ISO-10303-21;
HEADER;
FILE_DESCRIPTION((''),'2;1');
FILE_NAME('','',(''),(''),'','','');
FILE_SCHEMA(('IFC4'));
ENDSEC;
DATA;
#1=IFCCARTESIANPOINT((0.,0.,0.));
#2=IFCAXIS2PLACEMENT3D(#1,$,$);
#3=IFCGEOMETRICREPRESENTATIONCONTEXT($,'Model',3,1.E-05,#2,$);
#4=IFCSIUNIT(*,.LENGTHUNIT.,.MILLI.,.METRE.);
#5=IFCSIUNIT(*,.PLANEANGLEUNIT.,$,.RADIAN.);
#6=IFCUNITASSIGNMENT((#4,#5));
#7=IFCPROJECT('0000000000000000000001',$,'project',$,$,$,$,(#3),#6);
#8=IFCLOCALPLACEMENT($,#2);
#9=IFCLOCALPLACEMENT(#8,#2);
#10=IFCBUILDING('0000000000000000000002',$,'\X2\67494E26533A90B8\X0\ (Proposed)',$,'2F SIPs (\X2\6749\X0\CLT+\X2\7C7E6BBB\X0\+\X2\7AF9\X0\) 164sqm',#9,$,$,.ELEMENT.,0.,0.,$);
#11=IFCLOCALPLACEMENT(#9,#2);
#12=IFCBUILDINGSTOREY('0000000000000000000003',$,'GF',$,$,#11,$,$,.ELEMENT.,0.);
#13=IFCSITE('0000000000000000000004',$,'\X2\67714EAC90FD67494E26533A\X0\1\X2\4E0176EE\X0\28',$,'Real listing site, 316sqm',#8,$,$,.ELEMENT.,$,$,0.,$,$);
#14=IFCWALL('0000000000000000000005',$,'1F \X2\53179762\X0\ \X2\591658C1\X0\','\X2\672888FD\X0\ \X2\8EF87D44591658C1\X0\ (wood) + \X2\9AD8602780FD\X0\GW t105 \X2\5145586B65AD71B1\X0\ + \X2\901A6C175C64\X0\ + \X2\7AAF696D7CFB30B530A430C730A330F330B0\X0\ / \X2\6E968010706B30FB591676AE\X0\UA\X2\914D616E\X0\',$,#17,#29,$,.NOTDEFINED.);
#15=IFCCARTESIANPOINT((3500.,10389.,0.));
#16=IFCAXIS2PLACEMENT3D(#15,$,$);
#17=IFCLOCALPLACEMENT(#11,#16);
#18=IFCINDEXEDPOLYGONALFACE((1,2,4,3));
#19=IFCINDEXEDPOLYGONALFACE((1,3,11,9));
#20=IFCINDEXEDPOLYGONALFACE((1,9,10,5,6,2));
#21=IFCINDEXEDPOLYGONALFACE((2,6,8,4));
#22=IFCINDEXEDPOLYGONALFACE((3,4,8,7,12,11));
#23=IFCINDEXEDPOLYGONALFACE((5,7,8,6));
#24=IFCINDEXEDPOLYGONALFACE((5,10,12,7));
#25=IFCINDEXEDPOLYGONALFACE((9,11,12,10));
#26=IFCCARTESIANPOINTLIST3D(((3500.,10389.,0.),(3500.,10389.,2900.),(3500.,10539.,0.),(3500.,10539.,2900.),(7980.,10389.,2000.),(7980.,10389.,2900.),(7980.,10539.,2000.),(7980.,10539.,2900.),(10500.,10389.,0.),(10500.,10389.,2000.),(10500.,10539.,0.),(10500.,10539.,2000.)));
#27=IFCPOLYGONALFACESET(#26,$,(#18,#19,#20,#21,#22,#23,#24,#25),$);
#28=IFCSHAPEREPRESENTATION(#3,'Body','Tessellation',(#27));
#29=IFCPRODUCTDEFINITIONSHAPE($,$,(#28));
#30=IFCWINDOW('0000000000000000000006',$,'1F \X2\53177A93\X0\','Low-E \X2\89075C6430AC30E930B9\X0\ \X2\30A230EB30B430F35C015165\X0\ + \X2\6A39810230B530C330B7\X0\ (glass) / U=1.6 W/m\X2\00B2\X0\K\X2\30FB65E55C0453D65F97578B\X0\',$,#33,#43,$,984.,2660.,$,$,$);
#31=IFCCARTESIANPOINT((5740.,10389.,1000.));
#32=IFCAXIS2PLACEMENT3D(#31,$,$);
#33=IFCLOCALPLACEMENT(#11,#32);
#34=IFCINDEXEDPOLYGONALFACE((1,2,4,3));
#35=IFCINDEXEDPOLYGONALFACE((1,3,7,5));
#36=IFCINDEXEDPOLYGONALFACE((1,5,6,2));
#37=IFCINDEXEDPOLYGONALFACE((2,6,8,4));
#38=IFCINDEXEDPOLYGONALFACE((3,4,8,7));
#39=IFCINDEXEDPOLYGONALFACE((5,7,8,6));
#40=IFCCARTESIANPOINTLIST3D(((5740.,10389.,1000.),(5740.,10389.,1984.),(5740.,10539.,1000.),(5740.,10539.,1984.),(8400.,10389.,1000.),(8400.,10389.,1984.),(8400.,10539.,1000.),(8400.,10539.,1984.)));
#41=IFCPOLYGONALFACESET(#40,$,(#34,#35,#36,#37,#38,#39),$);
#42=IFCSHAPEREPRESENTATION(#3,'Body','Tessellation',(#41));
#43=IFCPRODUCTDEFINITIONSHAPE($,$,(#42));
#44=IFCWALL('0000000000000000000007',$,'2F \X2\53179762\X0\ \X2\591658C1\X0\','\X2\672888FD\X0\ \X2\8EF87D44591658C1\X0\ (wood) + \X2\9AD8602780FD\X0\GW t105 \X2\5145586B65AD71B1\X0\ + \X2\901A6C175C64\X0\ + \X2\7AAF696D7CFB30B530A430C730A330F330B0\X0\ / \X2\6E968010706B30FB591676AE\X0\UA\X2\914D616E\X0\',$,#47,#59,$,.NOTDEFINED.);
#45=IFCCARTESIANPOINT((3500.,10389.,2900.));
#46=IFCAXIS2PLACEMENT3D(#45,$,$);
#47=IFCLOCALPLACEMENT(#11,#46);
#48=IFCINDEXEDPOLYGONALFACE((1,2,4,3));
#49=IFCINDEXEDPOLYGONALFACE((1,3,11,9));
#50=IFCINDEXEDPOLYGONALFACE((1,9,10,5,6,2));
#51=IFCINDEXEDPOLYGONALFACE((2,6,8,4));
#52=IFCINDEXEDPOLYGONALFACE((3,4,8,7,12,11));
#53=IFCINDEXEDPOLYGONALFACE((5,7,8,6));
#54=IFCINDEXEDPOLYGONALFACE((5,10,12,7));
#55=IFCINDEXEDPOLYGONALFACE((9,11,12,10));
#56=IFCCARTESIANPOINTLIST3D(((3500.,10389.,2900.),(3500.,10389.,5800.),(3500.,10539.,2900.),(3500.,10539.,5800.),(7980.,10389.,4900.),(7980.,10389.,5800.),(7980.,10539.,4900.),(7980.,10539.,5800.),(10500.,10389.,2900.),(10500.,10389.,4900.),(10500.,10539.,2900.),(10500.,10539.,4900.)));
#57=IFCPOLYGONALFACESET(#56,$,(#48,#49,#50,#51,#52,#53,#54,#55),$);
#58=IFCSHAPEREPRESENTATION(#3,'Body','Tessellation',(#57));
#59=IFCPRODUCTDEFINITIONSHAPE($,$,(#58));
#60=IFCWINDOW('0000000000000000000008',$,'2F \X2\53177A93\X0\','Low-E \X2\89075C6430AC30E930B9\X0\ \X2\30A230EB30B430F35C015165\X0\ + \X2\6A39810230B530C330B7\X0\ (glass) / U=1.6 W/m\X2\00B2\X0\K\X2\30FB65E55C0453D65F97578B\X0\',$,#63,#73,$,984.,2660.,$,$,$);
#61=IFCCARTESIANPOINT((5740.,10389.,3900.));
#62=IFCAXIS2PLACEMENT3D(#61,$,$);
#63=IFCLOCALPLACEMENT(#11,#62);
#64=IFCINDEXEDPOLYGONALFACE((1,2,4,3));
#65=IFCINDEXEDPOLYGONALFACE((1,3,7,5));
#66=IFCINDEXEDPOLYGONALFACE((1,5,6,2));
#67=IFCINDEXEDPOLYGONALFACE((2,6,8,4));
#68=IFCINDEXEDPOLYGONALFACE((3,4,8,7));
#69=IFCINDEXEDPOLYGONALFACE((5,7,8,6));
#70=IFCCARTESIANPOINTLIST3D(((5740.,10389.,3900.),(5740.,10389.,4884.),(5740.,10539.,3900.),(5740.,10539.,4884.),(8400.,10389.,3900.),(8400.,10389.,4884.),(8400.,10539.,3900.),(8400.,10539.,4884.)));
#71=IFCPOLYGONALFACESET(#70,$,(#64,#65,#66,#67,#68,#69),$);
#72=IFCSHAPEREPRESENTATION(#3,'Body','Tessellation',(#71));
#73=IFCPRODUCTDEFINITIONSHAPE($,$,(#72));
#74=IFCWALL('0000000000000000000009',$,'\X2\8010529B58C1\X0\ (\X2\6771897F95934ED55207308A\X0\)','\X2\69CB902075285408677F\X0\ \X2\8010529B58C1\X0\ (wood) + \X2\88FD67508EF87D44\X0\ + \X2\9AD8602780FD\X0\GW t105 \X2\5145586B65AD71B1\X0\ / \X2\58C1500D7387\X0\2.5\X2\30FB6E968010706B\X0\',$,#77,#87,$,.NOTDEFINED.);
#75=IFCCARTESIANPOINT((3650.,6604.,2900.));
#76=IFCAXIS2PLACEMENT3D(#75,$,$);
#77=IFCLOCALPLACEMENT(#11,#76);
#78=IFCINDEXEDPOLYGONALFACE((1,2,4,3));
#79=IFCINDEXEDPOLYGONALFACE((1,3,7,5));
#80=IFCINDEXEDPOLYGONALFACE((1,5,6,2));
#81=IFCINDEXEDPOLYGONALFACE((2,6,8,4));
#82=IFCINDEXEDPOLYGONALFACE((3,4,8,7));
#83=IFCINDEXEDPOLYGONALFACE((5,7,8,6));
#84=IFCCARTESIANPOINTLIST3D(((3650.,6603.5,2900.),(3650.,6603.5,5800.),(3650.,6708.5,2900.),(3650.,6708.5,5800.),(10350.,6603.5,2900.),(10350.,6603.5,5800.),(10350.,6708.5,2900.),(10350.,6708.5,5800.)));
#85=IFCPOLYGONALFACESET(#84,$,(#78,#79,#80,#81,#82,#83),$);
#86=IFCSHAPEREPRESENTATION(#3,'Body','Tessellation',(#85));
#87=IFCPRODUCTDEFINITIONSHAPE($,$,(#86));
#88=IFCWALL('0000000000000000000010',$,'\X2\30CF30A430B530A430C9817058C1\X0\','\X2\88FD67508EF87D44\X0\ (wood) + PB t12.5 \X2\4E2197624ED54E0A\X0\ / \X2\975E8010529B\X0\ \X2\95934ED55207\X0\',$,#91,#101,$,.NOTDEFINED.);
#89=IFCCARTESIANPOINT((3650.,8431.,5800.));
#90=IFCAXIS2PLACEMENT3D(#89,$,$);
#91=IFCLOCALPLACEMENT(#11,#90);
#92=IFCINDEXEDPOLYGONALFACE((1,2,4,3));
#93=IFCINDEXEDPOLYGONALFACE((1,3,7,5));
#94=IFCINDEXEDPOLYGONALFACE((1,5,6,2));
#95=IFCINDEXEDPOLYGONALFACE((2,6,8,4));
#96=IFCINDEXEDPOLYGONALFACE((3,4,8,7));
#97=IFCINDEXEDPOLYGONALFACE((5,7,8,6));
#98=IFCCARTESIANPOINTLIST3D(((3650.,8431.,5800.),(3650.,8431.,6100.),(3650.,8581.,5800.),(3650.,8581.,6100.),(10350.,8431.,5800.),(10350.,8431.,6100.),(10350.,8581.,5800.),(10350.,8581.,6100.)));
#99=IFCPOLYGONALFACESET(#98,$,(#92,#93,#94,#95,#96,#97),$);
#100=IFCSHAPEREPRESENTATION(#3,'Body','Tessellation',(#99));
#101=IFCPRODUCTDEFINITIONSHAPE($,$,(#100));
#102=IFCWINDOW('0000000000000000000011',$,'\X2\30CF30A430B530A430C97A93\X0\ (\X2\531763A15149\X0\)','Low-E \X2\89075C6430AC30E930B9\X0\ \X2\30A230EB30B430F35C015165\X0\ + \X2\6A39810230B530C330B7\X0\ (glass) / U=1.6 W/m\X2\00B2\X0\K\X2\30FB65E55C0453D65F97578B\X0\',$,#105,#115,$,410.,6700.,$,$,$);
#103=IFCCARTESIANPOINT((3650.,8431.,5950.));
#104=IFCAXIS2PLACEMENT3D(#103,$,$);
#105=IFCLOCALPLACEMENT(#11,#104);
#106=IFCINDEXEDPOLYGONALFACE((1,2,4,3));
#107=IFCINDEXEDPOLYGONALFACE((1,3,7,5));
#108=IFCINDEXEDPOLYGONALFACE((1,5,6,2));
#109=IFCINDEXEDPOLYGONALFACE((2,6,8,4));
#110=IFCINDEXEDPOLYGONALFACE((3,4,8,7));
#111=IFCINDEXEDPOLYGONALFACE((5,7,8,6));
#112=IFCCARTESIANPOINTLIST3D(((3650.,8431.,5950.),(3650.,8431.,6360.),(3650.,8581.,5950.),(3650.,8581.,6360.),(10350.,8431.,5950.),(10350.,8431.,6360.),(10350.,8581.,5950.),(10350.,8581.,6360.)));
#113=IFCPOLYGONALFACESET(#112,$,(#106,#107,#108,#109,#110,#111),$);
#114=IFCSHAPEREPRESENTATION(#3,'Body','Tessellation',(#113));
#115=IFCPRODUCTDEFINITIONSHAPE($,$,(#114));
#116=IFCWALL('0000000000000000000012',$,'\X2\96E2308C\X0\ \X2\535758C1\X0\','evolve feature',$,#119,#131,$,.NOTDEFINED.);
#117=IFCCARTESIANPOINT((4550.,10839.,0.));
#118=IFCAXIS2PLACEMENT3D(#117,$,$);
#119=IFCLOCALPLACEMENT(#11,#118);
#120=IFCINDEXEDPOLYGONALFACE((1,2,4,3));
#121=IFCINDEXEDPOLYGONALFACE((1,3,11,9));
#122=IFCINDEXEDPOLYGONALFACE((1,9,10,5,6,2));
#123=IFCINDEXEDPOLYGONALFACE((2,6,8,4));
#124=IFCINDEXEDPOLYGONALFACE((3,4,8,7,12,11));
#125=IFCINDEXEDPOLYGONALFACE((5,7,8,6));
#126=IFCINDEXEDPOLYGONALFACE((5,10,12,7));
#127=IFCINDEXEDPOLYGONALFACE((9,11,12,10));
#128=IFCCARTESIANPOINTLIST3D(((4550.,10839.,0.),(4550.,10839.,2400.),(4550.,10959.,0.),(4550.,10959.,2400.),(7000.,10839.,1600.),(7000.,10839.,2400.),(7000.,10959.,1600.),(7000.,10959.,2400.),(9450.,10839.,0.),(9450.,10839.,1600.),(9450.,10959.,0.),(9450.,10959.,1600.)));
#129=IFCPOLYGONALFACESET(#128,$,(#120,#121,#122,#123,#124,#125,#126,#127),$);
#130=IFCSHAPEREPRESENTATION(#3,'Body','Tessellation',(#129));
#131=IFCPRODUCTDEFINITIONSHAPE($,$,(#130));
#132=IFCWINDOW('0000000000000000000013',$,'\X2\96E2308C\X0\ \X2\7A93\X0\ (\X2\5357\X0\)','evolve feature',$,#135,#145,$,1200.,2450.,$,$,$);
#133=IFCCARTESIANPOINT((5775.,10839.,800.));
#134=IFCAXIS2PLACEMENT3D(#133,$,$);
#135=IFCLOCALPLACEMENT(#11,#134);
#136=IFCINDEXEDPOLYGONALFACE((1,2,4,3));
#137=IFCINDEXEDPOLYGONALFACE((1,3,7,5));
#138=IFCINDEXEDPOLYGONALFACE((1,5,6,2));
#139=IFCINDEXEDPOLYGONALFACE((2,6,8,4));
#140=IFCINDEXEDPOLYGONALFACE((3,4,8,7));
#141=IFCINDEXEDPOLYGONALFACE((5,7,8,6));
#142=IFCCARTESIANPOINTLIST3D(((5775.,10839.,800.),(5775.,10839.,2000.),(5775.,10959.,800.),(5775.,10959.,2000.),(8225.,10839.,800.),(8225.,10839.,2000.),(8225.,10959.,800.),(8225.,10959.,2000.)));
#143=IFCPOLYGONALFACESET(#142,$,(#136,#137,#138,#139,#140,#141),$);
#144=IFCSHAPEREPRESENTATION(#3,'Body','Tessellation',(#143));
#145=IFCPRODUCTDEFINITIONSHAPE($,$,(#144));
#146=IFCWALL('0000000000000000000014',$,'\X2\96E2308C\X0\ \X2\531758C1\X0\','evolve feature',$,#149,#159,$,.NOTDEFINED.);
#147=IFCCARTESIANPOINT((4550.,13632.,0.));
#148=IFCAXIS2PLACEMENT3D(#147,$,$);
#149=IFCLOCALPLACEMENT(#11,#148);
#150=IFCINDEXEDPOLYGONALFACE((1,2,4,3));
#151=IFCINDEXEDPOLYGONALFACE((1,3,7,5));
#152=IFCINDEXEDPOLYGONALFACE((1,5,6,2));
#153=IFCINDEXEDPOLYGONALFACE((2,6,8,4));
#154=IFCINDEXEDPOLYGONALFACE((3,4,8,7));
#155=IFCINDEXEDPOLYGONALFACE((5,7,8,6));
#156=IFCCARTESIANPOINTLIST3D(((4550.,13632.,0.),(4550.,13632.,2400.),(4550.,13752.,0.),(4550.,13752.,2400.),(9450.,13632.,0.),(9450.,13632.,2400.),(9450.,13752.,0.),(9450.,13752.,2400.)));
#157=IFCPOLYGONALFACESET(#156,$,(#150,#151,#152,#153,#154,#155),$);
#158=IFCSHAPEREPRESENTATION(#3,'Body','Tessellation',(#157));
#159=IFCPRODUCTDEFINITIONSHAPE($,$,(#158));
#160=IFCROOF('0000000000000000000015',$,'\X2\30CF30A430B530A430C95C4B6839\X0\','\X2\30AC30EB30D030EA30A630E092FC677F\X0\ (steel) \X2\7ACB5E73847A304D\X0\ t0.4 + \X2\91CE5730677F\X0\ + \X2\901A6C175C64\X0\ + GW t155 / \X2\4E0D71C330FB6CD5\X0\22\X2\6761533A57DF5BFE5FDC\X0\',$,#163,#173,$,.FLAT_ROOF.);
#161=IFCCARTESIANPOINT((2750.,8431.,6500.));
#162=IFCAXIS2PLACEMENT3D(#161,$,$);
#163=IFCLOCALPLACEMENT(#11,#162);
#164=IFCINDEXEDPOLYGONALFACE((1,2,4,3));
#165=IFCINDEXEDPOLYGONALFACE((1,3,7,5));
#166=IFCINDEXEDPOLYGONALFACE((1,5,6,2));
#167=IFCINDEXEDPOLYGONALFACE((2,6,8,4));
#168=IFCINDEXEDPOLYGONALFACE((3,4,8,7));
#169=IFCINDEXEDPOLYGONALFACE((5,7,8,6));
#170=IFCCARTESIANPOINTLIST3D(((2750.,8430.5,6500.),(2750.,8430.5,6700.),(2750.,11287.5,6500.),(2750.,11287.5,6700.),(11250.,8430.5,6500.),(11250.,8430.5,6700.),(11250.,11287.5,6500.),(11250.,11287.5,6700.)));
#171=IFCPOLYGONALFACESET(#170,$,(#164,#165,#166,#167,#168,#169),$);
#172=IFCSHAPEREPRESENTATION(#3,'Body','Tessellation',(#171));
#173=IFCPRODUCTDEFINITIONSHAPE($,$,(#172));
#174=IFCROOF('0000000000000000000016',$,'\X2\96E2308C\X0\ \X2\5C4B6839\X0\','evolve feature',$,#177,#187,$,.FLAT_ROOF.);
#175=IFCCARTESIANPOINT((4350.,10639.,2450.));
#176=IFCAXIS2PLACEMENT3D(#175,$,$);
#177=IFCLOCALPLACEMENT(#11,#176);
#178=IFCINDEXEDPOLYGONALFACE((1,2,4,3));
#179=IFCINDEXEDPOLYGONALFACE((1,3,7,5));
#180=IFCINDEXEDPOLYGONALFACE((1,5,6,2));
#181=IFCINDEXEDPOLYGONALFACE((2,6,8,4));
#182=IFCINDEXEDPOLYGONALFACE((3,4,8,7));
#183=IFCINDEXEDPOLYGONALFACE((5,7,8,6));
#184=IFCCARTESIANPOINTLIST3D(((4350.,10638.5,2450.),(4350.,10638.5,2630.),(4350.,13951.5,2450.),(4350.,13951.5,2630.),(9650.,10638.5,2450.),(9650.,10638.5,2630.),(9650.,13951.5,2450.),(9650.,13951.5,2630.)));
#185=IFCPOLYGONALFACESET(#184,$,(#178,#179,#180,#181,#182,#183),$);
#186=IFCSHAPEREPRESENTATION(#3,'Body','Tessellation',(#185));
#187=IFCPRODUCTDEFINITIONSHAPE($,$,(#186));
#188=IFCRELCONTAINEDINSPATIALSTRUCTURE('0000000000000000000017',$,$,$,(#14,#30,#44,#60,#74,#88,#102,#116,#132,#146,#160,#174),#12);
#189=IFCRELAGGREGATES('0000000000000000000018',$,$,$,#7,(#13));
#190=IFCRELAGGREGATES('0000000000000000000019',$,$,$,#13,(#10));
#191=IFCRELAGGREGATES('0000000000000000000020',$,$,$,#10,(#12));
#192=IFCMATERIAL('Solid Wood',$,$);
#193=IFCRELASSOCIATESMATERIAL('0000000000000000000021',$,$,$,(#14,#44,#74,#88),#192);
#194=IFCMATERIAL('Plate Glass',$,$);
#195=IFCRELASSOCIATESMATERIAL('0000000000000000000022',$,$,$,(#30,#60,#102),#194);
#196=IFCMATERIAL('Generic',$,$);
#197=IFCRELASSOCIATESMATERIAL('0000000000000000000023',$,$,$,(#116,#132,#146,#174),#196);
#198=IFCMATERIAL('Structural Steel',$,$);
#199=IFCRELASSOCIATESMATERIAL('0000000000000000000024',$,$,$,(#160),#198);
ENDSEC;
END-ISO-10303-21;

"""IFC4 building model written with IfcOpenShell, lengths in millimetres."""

from ifc_helpers import new_model, si_unit, frame, frame_2d, origin, place, context, project, spatial, rectangle, extrude, material, element, fill, save


model = new_model("IFC4")

# Units and contexts
model_context = context("Model", 3, precision=1e-05, world=origin())
ifc_project = project(units=[si_unit("LENGTHUNIT", "METRE", prefix="MILLI"), si_unit("PLANEANGLEUNIT", "RADIAN")], contexts=[model_context])

# Site, building, storey
site_placement = place(None, origin())
site = spatial("IfcSite", under=ifc_project, at=site_placement, Name="東京都杉並区1丁目28", ObjectType="Real listing site, 316sqm", CompositionType="ELEMENT", RefElevation=0.0)
building_placement = place(site_placement, origin())
building = spatial("IfcBuilding", under=site, at=building_placement, Name="杉並区邸 (Proposed)", ObjectType="2F SIPs (杉CLT+籾殻+竹) 164sqm", CompositionType="ELEMENT", ElevationOfRefHeight=0.0, ElevationOfTerrain=0.0)
storey_placement = place(building_placement, origin())
storey = spatial("IfcBuildingStorey", under=building, at=storey_placement, Name="GF", CompositionType="ELEMENT", Elevation=0.0)

# Shared definitions
ifc_material_1 = material(Name="Generic")

# Wall, opening, window
ifc_material_2 = material(Name="Solid Wood")
wall_1_placement = place(storey_placement, frame((3500.0, 10389.0, 0.0)))
wall_1 = element("IfcWall", 1, at=wall_1_placement, inside=storey, material=ifc_material_2, Name="1F 北面 外壁", Description="木製 軸組外壁 (wood) + 高性能GW t105 充填断熱 + 通気層 + 窯業系サイディング / 準耐火・外皮UA配慮", PredefinedType="NOTDEFINED", context=model_context, shape_type="SweptSolid", body=[
    extrude(rectangle(XDim=7000.0, YDim=150.0, at=frame_2d((3500.0, 75.0))), frame((3500.0, 10389.0, 0.0)), (0.0, 0.0, 1.0), 2900.0),
])
opening_1_placement = place(storey_placement, frame((5740.0, 10389.0, 1000.0)))
opening_1 = element("IfcOpeningElement", 2, at=opening_1_placement, cuts=wall_1, PredefinedType="NOTDEFINED", context=model_context, shape_type="SweptSolid", body=[
    extrude(rectangle(XDim=2660.0, YDim=150.0, at=frame_2d((1330.0, 75.0))), frame((5740.0, 10389.0, 1000.0)), (0.0, 0.0, 1.0), 984.0),
])
ifc_material_3 = material(Name="Plate Glass")
window_1_placement = place(storey_placement, frame((5740.0, 10389.0, 1000.0)))
window_1 = element("IfcWindow", 3, at=window_1_placement, inside=storey, material=ifc_material_3, Name="1F 北窓", Description="Low-E 複層ガラス アルゴン封入 + 樹脂サッシ (glass) / U=1.6 W/m²K・日射取得型", OverallHeight=984.0, OverallWidth=2660.0, context=model_context, shape_type="SweptSolid", body=[
    extrude(rectangle(XDim=2660.0, YDim=150.0, at=frame_2d((1330.0, 75.0))), frame((5740.0, 10389.0, 1000.0)), (0.0, 0.0, 1.0), 984.0),
])
fill(opening_1, window_1)

# Wall, opening, window
wall_2_placement = place(storey_placement, frame((3500.0, 10389.0, 2900.0)))
wall_2 = element("IfcWall", 4, at=wall_2_placement, inside=storey, material=ifc_material_2, Name="2F 北面 外壁", Description="木製 軸組外壁 (wood) + 高性能GW t105 充填断熱 + 通気層 + 窯業系サイディング / 準耐火・外皮UA配慮", PredefinedType="NOTDEFINED", context=model_context, shape_type="SweptSolid", body=[
    extrude(rectangle(XDim=7000.0, YDim=150.0, at=frame_2d((3500.0, 75.0))), frame((3500.0, 10389.0, 2900.0)), (0.0, 0.0, 1.0), 2900.0),
])
opening_2_placement = place(storey_placement, frame((5740.0, 10389.0, 3900.0)))
opening_2 = element("IfcOpeningElement", 5, at=opening_2_placement, cuts=wall_2, PredefinedType="NOTDEFINED", context=model_context, shape_type="SweptSolid", body=[
    extrude(rectangle(XDim=2660.0, YDim=150.0, at=frame_2d((1330.0, 75.0))), frame((5740.0, 10389.0, 3900.0)), (0.0, 0.0, 1.0), 984.0),
])
window_2_placement = place(storey_placement, frame((5740.0, 10389.0, 3900.0)))
window_2 = element("IfcWindow", 6, at=window_2_placement, inside=storey, material=ifc_material_3, Name="2F 北窓", Description="Low-E 複層ガラス アルゴン封入 + 樹脂サッシ (glass) / U=1.6 W/m²K・日射取得型", OverallHeight=984.0, OverallWidth=2660.0, context=model_context, shape_type="SweptSolid", body=[
    extrude(rectangle(XDim=2660.0, YDim=150.0, at=frame_2d((1330.0, 75.0))), frame((5740.0, 10389.0, 3900.0)), (0.0, 0.0, 1.0), 984.0),
])
fill(opening_2, window_2)

# Wall
wall_3_placement = place(storey_placement, frame((3650.0, 6604.0, 2900.0)))
element("IfcWall", 7, at=wall_3_placement, inside=storey, material=ifc_material_2, Name="耐力壁 (東西間仕切り)", Description="構造用合板 耐力壁 (wood) + 製材軸組 + 高性能GW t105 充填断熱 / 壁倍率2.5・準耐火", PredefinedType="NOTDEFINED", context=model_context, shape_type="SweptSolid", body=[
    extrude(rectangle(XDim=6700.0, YDim=105.0, at=frame_2d((3350.0, 52.0))), frame((3650.0, 6604.0, 2900.0)), (0.0, 0.0, 1.0), 2900.0),
])

# Walls, openings, windows
wall_4_placement = place(storey_placement, frame((3650.0, 8431.0, 5800.0)))
wall_4 = element("IfcWall", 8, at=wall_4_placement, inside=storey, material=ifc_material_2, Name="ハイサイド腰壁", Description="製材軸組 (wood) + PB t12.5 両面仕上 / 非耐力 間仕切", PredefinedType="NOTDEFINED", context=model_context, shape_type="SweptSolid", body=[
    extrude(rectangle(XDim=6700.0, YDim=150.0, at=frame_2d((3350.0, 75.0))), frame((3650.0, 8431.0, 5800.0)), (0.0, 0.0, 1.0), 700.0),
])
opening_3_placement = place(storey_placement, frame((3650.0, 8431.0, 5950.0)))
opening_3 = element("IfcOpeningElement", 9, at=opening_3_placement, cuts=wall_4, PredefinedType="NOTDEFINED", context=model_context, shape_type="SweptSolid", body=[
    extrude(rectangle(XDim=6700.0, YDim=150.0, at=frame_2d((3350.0, 75.0))), frame((3650.0, 8431.0, 5950.0)), (0.0, 0.0, 1.0), 410.0),
])
window_3_placement = place(storey_placement, frame((3650.0, 8431.0, 5950.0)))
window_3 = element("IfcWindow", 10, at=window_3_placement, inside=storey, material=ifc_material_3, Name="ハイサイド窓 (北採光)", Description="Low-E 複層ガラス アルゴン封入 + 樹脂サッシ (glass) / U=1.6 W/m²K・日射取得型", OverallHeight=410.0, OverallWidth=6700.0, context=model_context, shape_type="SweptSolid", body=[
    extrude(rectangle(XDim=6700.0, YDim=150.0, at=frame_2d((3350.0, 75.0))), frame((3650.0, 8431.0, 5950.0)), (0.0, 0.0, 1.0), 410.0),
])
fill(opening_3, window_3)
wall_5_placement = place(storey_placement, frame((4550.0, 10839.0, 0.0)))
wall_5 = element("IfcWall", 11, at=wall_5_placement, inside=storey, material=ifc_material_1, Name="離れ 南壁", Description="evolve feature", PredefinedType="NOTDEFINED", context=model_context, shape_type="SweptSolid", body=[
    extrude(rectangle(XDim=4900.0, YDim=120.0, at=frame_2d((2450.0, 60.0))), frame((4550.0, 10839.0, 0.0)), (0.0, 0.0, 1.0), 2400.0),
])
opening_4_placement = place(storey_placement, frame((5775.0, 10839.0, 800.0)))
opening_4 = element("IfcOpeningElement", 12, at=opening_4_placement, cuts=wall_5, PredefinedType="NOTDEFINED", context=model_context, shape_type="SweptSolid", body=[
    extrude(rectangle(XDim=2450.0, YDim=120.0, at=frame_2d((1225.0, 60.0))), frame((5775.0, 10839.0, 800.0)), (0.0, 0.0, 1.0), 1200.0),
])
window_4_placement = place(storey_placement, frame((5775.0, 10839.0, 800.0)))
window_4 = element("IfcWindow", 13, at=window_4_placement, inside=storey, material=ifc_material_1, Name="離れ 窓 (南)", Description="evolve feature", OverallHeight=1200.0, OverallWidth=2450.0, context=model_context, shape_type="SweptSolid", body=[
    extrude(rectangle(XDim=2450.0, YDim=120.0, at=frame_2d((1225.0, 60.0))), frame((5775.0, 10839.0, 800.0)), (0.0, 0.0, 1.0), 1200.0),
])
fill(opening_4, window_4)

# Wall
wall_6_placement = place(storey_placement, frame((4550.0, 13632.0, 0.0)))
element("IfcWall", 14, at=wall_6_placement, inside=storey, material=ifc_material_1, Name="離れ 北壁", Description="evolve feature", PredefinedType="NOTDEFINED", context=model_context, shape_type="SweptSolid", body=[
    extrude(rectangle(XDim=4900.0, YDim=120.0, at=frame_2d((2450.0, 60.0))), frame((4550.0, 13632.0, 0.0)), (0.0, 0.0, 1.0), 2400.0),
])

# Roofs
ifc_material_4 = material(Name="Structural Steel")
roof_1_placement = place(storey_placement, frame((2750.0, 8431.0, 6500.0)))
element("IfcRoof", 15, at=roof_1_placement, inside=storey, material=ifc_material_4, Name="ハイサイド屋根", Description="ガルバリウム鋼板 (steel) 立平葺き t0.4 + 野地板 + 通気層 + GW t155 / 不燃・法22条区域対応", PredefinedType="FLAT_ROOF", context=model_context, shape_type="SweptSolid", body=[
    extrude(rectangle(XDim=8500.0, YDim=2857.0, at=frame_2d((4250.0, 1428.0))), frame((2750.0, 8431.0, 6500.0)), (0.0, 0.0, 1.0), 200.0),
])
roof_2_placement = place(storey_placement, frame((4350.0, 10639.0, 2450.0)))
element("IfcRoof", 16, at=roof_2_placement, inside=storey, material=ifc_material_1, Name="離れ 屋根", Description="evolve feature", PredefinedType="FLAT_ROOF", context=model_context, shape_type="SweptSolid", body=[
    extrude(rectangle(XDim=5300.0, YDim=3313.0, at=frame_2d((2650.0, 1656.0))), frame((4350.0, 10639.0, 2450.0)), (0.0, 0.0, 1.0), 180.0),
])

save(model, "model.ifc")
